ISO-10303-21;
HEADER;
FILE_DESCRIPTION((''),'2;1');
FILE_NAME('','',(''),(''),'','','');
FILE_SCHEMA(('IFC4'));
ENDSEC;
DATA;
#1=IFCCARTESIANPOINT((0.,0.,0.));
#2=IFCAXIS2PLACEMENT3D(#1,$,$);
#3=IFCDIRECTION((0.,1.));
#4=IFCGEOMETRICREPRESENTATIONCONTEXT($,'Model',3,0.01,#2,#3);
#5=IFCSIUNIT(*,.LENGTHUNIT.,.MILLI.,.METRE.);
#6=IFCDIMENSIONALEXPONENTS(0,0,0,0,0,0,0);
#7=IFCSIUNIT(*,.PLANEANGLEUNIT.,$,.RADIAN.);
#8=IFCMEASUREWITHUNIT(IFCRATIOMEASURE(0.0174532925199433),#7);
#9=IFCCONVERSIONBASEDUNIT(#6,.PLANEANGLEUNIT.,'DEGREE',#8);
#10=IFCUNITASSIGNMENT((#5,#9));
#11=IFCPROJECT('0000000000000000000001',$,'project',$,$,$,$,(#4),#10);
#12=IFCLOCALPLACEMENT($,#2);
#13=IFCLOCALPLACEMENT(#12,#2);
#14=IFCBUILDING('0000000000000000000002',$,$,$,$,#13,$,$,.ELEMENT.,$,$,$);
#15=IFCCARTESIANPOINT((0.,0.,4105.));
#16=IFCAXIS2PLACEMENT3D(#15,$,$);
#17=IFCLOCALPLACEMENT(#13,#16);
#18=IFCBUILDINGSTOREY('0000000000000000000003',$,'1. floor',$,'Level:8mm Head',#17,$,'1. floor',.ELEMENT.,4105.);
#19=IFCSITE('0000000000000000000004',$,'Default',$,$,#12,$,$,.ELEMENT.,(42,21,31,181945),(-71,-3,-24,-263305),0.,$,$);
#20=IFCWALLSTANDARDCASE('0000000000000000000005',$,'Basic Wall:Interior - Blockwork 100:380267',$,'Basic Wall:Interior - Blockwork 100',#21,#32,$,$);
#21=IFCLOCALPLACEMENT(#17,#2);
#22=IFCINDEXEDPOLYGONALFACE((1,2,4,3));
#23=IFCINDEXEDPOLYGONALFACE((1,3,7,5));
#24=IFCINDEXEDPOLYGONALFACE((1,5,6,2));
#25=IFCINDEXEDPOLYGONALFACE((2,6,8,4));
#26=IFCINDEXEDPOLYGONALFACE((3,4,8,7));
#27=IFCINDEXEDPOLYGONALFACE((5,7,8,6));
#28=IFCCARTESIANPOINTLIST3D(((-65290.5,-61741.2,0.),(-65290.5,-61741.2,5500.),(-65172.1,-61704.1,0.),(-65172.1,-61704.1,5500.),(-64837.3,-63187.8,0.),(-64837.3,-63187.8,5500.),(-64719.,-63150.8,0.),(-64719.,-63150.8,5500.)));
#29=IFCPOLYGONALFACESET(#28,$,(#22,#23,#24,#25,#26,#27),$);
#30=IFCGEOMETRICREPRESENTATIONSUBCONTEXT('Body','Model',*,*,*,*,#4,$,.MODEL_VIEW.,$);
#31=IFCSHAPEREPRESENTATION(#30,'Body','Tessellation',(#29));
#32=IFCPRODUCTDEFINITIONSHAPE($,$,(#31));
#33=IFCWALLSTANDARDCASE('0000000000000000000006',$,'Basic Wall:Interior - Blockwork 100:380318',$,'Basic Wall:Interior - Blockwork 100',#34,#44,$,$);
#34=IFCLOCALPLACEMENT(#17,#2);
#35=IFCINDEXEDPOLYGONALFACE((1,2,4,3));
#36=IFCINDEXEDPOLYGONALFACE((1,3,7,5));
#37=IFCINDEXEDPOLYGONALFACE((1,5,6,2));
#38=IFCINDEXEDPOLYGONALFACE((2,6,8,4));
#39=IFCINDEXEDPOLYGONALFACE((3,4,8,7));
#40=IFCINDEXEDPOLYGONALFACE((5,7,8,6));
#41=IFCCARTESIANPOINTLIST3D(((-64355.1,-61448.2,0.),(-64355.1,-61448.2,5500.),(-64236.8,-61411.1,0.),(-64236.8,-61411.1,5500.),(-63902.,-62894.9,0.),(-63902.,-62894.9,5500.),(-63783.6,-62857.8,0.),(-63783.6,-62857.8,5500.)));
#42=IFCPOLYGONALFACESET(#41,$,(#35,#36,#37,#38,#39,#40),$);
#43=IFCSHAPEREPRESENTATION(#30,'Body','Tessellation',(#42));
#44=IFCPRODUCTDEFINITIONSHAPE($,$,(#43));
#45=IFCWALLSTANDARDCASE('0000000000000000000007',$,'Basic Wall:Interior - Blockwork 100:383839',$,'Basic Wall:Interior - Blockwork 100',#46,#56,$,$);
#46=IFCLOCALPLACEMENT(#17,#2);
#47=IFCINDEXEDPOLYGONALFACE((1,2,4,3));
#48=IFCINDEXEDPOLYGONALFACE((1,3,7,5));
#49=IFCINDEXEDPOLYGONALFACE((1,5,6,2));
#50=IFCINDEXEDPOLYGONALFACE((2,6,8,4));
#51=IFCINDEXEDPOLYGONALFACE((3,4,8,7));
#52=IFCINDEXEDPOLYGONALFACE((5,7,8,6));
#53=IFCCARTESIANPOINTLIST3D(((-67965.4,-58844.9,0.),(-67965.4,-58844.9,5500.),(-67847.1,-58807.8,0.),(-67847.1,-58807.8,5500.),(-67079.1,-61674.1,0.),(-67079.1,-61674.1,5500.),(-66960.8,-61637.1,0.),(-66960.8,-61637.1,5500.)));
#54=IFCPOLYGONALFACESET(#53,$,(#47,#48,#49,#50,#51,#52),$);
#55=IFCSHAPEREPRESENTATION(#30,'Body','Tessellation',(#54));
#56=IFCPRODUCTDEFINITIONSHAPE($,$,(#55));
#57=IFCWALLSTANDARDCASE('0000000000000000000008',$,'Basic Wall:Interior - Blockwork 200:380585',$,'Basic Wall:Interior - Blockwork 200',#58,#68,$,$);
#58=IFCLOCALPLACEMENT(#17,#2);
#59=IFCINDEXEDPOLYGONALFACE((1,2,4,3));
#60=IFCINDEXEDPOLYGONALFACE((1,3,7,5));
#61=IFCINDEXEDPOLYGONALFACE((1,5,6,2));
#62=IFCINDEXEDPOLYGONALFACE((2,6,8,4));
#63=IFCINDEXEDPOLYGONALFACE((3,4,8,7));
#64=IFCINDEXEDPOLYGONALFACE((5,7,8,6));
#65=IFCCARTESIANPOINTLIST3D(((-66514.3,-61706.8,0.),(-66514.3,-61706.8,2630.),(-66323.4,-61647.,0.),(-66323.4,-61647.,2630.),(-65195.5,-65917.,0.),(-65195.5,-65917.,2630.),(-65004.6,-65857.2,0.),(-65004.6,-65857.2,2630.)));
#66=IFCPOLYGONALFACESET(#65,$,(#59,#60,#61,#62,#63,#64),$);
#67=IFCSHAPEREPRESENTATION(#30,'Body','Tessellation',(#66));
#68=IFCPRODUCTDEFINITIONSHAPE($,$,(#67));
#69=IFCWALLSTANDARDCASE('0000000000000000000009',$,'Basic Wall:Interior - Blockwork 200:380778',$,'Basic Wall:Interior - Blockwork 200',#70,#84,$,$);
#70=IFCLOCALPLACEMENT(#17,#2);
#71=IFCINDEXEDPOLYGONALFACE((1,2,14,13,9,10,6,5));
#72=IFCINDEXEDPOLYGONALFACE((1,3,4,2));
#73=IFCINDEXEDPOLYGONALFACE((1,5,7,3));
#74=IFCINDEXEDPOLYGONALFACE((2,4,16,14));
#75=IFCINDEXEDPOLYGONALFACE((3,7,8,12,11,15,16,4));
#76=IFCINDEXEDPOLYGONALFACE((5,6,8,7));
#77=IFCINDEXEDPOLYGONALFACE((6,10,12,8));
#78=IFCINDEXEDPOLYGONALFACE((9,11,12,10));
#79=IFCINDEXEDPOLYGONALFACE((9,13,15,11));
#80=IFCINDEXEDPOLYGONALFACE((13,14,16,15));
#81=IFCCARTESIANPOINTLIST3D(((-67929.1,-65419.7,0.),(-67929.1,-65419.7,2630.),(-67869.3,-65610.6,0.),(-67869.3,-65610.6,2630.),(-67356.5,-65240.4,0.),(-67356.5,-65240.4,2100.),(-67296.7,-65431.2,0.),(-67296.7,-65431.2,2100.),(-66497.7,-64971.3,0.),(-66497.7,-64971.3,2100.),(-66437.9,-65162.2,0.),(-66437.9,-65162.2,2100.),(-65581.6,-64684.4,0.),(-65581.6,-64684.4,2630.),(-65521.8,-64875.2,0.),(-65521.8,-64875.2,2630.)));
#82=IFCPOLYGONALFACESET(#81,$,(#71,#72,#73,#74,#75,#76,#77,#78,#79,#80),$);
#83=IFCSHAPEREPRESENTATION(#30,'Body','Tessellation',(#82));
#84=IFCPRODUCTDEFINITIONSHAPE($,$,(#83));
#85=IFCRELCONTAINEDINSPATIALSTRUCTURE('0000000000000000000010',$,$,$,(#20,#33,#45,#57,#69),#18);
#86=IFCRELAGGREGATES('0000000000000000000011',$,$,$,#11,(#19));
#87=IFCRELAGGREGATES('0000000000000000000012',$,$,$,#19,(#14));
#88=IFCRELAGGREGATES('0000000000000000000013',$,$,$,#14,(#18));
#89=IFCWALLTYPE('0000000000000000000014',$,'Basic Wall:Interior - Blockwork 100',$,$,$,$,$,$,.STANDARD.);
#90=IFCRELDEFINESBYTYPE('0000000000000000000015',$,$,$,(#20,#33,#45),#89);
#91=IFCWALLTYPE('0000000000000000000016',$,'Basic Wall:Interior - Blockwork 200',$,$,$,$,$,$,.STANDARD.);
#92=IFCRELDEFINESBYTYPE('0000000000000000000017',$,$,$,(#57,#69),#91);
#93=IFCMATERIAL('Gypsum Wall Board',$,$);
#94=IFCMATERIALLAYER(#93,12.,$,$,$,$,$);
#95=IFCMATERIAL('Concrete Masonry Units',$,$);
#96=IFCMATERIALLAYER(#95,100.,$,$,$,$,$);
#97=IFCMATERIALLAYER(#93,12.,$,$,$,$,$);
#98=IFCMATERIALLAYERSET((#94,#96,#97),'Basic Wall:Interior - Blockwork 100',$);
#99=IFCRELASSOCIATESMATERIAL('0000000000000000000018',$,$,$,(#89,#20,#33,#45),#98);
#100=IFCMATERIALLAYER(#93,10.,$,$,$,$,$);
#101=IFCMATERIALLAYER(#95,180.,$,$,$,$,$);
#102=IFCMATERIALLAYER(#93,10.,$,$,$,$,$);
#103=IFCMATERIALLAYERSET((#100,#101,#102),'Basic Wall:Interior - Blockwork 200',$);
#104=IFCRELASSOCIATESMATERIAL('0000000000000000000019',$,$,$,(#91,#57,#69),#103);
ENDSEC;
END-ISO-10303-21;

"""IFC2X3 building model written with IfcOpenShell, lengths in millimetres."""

from ifc_helpers import new_model, entity, si_unit, converted_unit, direction, frame, frame_2d, origin, place, context, subcontext, project, spatial, rectangle, extrude, material, layer, layer_set, layer_usage, type_object, element, save


model = new_model("IFC2X3")

# Units and contexts
model_context = context("Model", 3, precision=0.01, world=origin(), true_north=direction((0.0, 1.0)))
body_context = subcontext(model_context, "Body", "Model", "MODEL_VIEW")
ifc_project = project(units=[si_unit("LENGTHUNIT", "METRE", prefix="MILLI"), converted_unit("PLANEANGLEUNIT", "DEGREE", entity("IfcRatioMeasure", 0.0174532925199433), si_unit("PLANEANGLEUNIT", "RADIAN"), dimensions=[0, 0, 0, 0, 0, 0, 0])], contexts=[model_context])

# Site, building, storey
site_placement = place(None, origin())
site = spatial("IfcSite", under=ifc_project, at=site_placement, Name="Default", CompositionType="ELEMENT", RefLatitude=(42, 21, 31, 181945), RefLongitude=(-71, -3, -24, -263305), RefElevation=0.0)
building_placement = place(site_placement, origin())
building = spatial("IfcBuilding", under=site, at=building_placement, CompositionType="ELEMENT")
storey_placement = place(building_placement, frame((0.0, 0.0, 4105.0)))
storey = spatial("IfcBuildingStorey", under=building, at=storey_placement, Name="1. floor", ObjectType="Level:8mm Head", LongName="1. floor", CompositionType="ELEMENT", Elevation=4105.0)

# Shared definitions
ifc_material_1 = material(Name="Gypsum Wall Board")
ifc_layer_1 = layer(ifc_material_1, 12.0)
ifc_material_2 = material(Name="Concrete Masonry Units")
ifc_layer_2 = layer(ifc_material_2, 100.0)
ifc_layer_3 = layer(ifc_material_1, 12.0)
ifc_layer_set_1 = layer_set([ifc_layer_1, ifc_layer_2, ifc_layer_3], Name="Basic Wall:Interior - Blockwork 100")
wall_type_1 = type_object("IfcWallType", Name="Basic Wall:Interior - Blockwork 100", PredefinedType="STANDARD", material=ifc_layer_set_1)

# Walls
ifc_layer_usage_1 = layer_usage(ifc_layer_set_1, "AXIS2", "NEGATIVE", 62.0)
wall_1_placement = place(storey_placement, frame((-65231.3, -61722.6, 0.0), z_axis=(0.0, 0.0, 1.0), x_axis=(0.298924, -0.954277, 0.0)))
element("IfcWallStandardCase", 1, at=wall_1_placement, inside=storey, type_object=wall_type_1, material=ifc_layer_usage_1, Name="Basic Wall:Interior - Blockwork 100:380267", ObjectType="Basic Wall:Interior - Blockwork 100", context=body_context, shape_type="SweptSolid", body=[
    extrude(rectangle(XDim=1516.0, YDim=124.0, at=frame_2d((758.0, 0.0), x_axis=(-1.0, 0.0))), origin(), (0.0, 0.0, 1.0), 5500.0),
])
ifc_layer_usage_2 = layer_usage(ifc_layer_set_1, "AXIS2", "NEGATIVE", 62.0)
wall_2_placement = place(storey_placement, frame((-64296.0, -61429.6, 0.0), z_axis=(0.0, 0.0, 1.0), x_axis=(0.298924, -0.954277, 0.0)))
element("IfcWallStandardCase", 2, at=wall_2_placement, inside=storey, type_object=wall_type_1, material=ifc_layer_usage_2, Name="Basic Wall:Interior - Blockwork 100:380318", ObjectType="Basic Wall:Interior - Blockwork 100", context=body_context, shape_type="SweptSolid", body=[
    extrude(rectangle(XDim=1516.0, YDim=124.0, at=frame_2d((758.0, 0.0), x_axis=(-1.0, 0.0))), origin(), (0.0, 0.0, 1.0), 5500.0),
])
ifc_layer_usage_3 = layer_usage(ifc_layer_set_1, "AXIS2", "NEGATIVE", 62.0)
wall_3_placement = place(storey_placement, frame((-67906.2, -58826.3, 0.0), z_axis=(0.0, 0.0, 1.0), x_axis=(0.298924, -0.954277, 0.0)))
element("IfcWallStandardCase", 3, at=wall_3_placement, inside=storey, type_object=wall_type_1, material=ifc_layer_usage_3, Name="Basic Wall:Interior - Blockwork 100:383839", ObjectType="Basic Wall:Interior - Blockwork 100", context=body_context, shape_type="SweptSolid", body=[
    extrude(rectangle(XDim=2964.8, YDim=124.0, at=frame_2d((1482.4, 0.0), x_axis=(-1.0, 0.0))), origin(), (0.0, 0.0, 1.0), 5500.0),
])
ifc_layer_4 = layer(ifc_material_1, 10.0)
ifc_layer_5 = layer(ifc_material_2, 180.0)
ifc_layer_6 = layer(ifc_material_1, 10.0)
ifc_layer_set_2 = layer_set([ifc_layer_4, ifc_layer_5, ifc_layer_6], Name="Basic Wall:Interior - Blockwork 200")
ifc_layer_usage_4 = layer_usage(ifc_layer_set_2, "AXIS2", "NEGATIVE", 100.0)
wall_type_2 = type_object("IfcWallType", Name="Basic Wall:Interior - Blockwork 200", PredefinedType="STANDARD", material=ifc_layer_set_2)
wall_4_placement = place(storey_placement, frame((-66418.9, -61676.9, 0.0), z_axis=(0.0, 0.0, 1.0), x_axis=(0.298924, -0.954277, 0.0)))
element("IfcWallStandardCase", 4, at=wall_4_placement, inside=storey, type_object=wall_type_2, material=ifc_layer_usage_4, Name="Basic Wall:Interior - Blockwork 200:380585", ObjectType="Basic Wall:Interior - Blockwork 200", context=body_context, shape_type="SweptSolid", body=[
    extrude(rectangle(XDim=4412.0, YDim=200.0, at=frame_2d((2206.0, 0.0), x_axis=(-1.0, 0.0))), origin(), (0.0, 0.0, 1.0), 2630.0),
])

# Wall, opening
ifc_layer_usage_5 = layer_usage(ifc_layer_set_2, "AXIS2", "NEGATIVE", 100.0)
wall_5_placement = place(storey_placement, frame((-65551.7, -64779.8, 0.0), z_axis=(0.0, 0.0, 1.0), x_axis=(-0.954277, -0.298924, 0.0)))
wall_5 = element("IfcWallStandardCase", 5, at=wall_5_placement, inside=storey, type_object=wall_type_2, material=ifc_layer_usage_5, Name="Basic Wall:Interior - Blockwork 200:380778", ObjectType="Basic Wall:Interior - Blockwork 200", context=body_context, shape_type="SweptSolid", body=[
    extrude(rectangle(XDim=2460.0, YDim=200.0, at=frame_2d((1230.0, 0.0), x_axis=(-1.0, 0.0))), origin(), (0.0, 0.0, 1.0), 2630.0),
])
opening_1_placement = place(wall_5_placement, origin())
element("IfcOpeningElement", 6, at=opening_1_placement, cuts=wall_5, ObjectType="Opening", context=body_context, shape_type="SweptSolid", body=[
    extrude(rectangle(XDim=2100.0, YDim=900.0, at=frame_2d((0.0, 0.0), x_axis=(0.0, 1.0))), frame((1410.0, -1624.0, 1050.0), z_axis=(0.0, 1.0, 0.0), x_axis=(-1.0, 0.0, 0.0)), (0.0, 0.0, 1.0), 3048.0),
])

save(model, "model.ifc")
